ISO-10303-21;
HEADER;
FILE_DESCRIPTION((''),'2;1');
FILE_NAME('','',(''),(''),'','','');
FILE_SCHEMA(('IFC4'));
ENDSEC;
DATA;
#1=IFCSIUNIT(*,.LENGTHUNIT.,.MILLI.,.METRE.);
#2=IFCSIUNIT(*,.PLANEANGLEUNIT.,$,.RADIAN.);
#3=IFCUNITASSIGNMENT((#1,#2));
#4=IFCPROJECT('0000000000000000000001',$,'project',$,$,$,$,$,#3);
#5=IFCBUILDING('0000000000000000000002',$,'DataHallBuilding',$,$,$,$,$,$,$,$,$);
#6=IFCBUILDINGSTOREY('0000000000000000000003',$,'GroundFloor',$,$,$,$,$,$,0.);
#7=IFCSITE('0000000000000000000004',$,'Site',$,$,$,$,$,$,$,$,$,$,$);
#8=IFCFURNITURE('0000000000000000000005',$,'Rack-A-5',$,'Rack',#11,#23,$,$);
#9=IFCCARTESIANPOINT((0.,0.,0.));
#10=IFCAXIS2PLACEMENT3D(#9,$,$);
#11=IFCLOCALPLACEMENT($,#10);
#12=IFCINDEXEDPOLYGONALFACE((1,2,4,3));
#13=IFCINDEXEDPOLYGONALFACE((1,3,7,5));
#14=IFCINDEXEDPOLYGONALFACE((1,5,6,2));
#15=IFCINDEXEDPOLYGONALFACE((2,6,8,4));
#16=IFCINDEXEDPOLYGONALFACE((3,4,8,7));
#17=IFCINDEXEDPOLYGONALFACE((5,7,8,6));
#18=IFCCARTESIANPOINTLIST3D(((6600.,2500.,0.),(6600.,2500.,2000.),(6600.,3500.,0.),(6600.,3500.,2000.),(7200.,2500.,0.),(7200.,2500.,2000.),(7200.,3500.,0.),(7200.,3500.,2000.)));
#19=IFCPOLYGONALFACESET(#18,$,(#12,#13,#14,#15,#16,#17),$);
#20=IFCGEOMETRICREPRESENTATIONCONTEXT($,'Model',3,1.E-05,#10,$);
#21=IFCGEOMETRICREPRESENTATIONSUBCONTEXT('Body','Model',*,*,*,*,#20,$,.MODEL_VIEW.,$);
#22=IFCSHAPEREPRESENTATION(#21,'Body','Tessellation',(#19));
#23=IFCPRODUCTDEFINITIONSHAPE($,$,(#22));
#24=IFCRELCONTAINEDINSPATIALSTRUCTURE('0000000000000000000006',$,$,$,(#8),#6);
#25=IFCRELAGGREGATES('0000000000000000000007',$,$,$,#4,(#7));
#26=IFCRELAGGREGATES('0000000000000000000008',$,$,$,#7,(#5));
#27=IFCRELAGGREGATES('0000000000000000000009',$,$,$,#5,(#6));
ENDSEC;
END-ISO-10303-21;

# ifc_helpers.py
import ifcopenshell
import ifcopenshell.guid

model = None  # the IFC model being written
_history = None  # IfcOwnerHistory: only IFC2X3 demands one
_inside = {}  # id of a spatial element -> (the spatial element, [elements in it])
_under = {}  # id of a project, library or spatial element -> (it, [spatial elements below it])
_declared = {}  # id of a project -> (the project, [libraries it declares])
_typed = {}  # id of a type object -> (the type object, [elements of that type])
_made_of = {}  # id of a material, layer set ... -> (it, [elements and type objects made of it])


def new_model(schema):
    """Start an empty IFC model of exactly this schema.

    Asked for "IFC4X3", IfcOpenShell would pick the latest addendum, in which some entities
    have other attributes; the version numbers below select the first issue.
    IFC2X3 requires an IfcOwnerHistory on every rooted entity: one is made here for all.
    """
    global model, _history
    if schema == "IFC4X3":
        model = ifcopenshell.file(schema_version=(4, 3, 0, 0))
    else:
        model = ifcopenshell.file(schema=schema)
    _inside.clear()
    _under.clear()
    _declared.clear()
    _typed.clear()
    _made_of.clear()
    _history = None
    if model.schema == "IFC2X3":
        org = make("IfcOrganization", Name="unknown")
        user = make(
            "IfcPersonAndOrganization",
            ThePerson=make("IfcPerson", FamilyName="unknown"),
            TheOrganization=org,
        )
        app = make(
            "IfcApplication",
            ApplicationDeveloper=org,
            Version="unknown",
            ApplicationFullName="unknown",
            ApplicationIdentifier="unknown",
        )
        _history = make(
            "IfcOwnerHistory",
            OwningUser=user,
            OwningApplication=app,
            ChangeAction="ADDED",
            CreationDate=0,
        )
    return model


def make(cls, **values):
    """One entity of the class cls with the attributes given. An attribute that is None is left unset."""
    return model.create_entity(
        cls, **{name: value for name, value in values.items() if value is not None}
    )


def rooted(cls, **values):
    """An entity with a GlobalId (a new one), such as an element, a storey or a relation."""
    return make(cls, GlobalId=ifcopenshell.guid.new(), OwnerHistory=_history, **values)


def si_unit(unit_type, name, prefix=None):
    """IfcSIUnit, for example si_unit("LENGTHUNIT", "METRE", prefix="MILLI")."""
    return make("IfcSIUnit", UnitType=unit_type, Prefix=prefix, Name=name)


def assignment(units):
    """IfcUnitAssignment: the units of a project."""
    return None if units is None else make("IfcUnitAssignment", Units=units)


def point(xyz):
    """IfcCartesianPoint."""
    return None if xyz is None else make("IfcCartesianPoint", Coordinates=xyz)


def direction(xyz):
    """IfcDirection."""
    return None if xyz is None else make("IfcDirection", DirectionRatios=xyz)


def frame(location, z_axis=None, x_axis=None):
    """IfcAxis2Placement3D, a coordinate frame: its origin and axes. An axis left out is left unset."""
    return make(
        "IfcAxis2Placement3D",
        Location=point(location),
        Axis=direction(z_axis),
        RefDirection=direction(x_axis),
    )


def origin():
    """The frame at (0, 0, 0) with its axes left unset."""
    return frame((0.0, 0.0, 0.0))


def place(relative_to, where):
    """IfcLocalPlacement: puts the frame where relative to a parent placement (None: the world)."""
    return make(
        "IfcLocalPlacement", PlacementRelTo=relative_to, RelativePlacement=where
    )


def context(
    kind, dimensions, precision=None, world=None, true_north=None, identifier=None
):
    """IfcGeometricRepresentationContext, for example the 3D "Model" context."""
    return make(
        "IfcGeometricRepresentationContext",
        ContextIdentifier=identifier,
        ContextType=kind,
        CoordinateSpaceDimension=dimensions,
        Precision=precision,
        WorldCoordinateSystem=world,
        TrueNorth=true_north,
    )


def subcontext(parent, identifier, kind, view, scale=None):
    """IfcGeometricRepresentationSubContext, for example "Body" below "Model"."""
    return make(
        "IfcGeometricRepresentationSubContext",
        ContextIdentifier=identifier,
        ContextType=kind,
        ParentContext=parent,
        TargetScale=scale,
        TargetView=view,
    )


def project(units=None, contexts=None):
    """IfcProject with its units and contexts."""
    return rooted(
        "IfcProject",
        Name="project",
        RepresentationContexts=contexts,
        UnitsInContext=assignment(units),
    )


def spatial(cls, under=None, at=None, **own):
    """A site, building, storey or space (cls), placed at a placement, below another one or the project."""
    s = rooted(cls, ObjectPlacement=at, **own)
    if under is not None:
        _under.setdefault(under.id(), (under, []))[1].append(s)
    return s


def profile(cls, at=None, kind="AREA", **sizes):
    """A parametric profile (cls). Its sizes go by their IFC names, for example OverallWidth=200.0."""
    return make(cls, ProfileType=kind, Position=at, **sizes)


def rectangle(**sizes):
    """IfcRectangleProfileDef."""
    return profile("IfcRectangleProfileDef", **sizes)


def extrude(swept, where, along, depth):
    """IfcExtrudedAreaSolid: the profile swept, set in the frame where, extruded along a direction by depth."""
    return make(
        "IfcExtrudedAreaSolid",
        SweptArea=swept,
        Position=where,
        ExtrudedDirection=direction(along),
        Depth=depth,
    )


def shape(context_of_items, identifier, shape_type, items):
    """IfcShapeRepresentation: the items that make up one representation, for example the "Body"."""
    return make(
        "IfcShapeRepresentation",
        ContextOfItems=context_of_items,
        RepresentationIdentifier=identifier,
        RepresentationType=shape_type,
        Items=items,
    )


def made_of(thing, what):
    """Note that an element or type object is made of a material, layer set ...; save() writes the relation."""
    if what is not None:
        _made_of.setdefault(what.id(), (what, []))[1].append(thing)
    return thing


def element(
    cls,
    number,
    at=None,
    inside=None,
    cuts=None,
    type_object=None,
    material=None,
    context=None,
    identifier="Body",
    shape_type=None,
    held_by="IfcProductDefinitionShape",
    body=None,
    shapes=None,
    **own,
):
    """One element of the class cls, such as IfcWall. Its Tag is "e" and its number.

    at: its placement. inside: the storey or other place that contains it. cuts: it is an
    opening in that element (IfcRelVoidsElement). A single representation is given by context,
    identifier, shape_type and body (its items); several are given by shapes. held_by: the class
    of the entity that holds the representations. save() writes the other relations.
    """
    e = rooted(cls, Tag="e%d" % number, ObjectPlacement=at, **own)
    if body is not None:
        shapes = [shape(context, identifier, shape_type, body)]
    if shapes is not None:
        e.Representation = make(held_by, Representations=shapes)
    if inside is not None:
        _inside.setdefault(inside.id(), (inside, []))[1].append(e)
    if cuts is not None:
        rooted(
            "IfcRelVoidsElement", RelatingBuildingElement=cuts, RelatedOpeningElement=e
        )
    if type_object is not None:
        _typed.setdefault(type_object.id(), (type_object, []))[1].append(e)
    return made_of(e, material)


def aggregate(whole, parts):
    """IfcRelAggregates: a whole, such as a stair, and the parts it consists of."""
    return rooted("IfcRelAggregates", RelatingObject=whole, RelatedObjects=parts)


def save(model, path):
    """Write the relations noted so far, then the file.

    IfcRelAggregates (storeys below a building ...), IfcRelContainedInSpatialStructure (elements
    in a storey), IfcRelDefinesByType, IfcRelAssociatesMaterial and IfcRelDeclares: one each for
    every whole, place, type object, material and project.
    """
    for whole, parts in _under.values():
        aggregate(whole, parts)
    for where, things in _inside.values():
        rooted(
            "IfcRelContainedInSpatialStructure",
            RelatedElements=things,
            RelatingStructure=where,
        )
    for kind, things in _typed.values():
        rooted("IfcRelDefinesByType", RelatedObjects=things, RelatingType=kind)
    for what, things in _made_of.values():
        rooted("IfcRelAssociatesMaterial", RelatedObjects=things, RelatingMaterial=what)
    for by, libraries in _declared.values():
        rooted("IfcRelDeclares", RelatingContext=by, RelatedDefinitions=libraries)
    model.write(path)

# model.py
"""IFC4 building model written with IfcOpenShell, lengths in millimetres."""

from ifc_helpers import new_model, si_unit, frame, origin, place, context, subcontext, project, spatial, rectangle, extrude, element, save


model = new_model("IFC4")

# Units and contexts
model_context = context("Model", 3, precision=1e-05, world=origin())
body_context = subcontext(model_context, "Body", "Model", "MODEL_VIEW")
ifc_project = project(units=[si_unit("LENGTHUNIT", "METRE", prefix="MILLI"), si_unit("PLANEANGLEUNIT", "RADIAN")])

# Site, building, storey
site = spatial("IfcSite", under=ifc_project, Name="Site")
building = spatial("IfcBuilding", under=site, Name="DataHallBuilding")
storey = spatial("IfcBuildingStorey", under=building, Name="GroundFloor", Elevation=0.0)

# Furniture
furniture_1_placement = place(None, origin())
element("IfcFurniture", 1, at=furniture_1_placement, inside=storey, Name="Rack-A-5", ObjectType="Rack", context=body_context, shape_type="SweptSolid", body=[
    extrude(rectangle(XDim=600.0, YDim=1000.0), frame((6900.0, 3000.0, 0.0), z_axis=(0.0, 0.0, 1.0), x_axis=(1.0, 0.0, 0.0)), (0.0, 0.0, 1.0), 2000.0),
])

save(model, "model.ifc")
